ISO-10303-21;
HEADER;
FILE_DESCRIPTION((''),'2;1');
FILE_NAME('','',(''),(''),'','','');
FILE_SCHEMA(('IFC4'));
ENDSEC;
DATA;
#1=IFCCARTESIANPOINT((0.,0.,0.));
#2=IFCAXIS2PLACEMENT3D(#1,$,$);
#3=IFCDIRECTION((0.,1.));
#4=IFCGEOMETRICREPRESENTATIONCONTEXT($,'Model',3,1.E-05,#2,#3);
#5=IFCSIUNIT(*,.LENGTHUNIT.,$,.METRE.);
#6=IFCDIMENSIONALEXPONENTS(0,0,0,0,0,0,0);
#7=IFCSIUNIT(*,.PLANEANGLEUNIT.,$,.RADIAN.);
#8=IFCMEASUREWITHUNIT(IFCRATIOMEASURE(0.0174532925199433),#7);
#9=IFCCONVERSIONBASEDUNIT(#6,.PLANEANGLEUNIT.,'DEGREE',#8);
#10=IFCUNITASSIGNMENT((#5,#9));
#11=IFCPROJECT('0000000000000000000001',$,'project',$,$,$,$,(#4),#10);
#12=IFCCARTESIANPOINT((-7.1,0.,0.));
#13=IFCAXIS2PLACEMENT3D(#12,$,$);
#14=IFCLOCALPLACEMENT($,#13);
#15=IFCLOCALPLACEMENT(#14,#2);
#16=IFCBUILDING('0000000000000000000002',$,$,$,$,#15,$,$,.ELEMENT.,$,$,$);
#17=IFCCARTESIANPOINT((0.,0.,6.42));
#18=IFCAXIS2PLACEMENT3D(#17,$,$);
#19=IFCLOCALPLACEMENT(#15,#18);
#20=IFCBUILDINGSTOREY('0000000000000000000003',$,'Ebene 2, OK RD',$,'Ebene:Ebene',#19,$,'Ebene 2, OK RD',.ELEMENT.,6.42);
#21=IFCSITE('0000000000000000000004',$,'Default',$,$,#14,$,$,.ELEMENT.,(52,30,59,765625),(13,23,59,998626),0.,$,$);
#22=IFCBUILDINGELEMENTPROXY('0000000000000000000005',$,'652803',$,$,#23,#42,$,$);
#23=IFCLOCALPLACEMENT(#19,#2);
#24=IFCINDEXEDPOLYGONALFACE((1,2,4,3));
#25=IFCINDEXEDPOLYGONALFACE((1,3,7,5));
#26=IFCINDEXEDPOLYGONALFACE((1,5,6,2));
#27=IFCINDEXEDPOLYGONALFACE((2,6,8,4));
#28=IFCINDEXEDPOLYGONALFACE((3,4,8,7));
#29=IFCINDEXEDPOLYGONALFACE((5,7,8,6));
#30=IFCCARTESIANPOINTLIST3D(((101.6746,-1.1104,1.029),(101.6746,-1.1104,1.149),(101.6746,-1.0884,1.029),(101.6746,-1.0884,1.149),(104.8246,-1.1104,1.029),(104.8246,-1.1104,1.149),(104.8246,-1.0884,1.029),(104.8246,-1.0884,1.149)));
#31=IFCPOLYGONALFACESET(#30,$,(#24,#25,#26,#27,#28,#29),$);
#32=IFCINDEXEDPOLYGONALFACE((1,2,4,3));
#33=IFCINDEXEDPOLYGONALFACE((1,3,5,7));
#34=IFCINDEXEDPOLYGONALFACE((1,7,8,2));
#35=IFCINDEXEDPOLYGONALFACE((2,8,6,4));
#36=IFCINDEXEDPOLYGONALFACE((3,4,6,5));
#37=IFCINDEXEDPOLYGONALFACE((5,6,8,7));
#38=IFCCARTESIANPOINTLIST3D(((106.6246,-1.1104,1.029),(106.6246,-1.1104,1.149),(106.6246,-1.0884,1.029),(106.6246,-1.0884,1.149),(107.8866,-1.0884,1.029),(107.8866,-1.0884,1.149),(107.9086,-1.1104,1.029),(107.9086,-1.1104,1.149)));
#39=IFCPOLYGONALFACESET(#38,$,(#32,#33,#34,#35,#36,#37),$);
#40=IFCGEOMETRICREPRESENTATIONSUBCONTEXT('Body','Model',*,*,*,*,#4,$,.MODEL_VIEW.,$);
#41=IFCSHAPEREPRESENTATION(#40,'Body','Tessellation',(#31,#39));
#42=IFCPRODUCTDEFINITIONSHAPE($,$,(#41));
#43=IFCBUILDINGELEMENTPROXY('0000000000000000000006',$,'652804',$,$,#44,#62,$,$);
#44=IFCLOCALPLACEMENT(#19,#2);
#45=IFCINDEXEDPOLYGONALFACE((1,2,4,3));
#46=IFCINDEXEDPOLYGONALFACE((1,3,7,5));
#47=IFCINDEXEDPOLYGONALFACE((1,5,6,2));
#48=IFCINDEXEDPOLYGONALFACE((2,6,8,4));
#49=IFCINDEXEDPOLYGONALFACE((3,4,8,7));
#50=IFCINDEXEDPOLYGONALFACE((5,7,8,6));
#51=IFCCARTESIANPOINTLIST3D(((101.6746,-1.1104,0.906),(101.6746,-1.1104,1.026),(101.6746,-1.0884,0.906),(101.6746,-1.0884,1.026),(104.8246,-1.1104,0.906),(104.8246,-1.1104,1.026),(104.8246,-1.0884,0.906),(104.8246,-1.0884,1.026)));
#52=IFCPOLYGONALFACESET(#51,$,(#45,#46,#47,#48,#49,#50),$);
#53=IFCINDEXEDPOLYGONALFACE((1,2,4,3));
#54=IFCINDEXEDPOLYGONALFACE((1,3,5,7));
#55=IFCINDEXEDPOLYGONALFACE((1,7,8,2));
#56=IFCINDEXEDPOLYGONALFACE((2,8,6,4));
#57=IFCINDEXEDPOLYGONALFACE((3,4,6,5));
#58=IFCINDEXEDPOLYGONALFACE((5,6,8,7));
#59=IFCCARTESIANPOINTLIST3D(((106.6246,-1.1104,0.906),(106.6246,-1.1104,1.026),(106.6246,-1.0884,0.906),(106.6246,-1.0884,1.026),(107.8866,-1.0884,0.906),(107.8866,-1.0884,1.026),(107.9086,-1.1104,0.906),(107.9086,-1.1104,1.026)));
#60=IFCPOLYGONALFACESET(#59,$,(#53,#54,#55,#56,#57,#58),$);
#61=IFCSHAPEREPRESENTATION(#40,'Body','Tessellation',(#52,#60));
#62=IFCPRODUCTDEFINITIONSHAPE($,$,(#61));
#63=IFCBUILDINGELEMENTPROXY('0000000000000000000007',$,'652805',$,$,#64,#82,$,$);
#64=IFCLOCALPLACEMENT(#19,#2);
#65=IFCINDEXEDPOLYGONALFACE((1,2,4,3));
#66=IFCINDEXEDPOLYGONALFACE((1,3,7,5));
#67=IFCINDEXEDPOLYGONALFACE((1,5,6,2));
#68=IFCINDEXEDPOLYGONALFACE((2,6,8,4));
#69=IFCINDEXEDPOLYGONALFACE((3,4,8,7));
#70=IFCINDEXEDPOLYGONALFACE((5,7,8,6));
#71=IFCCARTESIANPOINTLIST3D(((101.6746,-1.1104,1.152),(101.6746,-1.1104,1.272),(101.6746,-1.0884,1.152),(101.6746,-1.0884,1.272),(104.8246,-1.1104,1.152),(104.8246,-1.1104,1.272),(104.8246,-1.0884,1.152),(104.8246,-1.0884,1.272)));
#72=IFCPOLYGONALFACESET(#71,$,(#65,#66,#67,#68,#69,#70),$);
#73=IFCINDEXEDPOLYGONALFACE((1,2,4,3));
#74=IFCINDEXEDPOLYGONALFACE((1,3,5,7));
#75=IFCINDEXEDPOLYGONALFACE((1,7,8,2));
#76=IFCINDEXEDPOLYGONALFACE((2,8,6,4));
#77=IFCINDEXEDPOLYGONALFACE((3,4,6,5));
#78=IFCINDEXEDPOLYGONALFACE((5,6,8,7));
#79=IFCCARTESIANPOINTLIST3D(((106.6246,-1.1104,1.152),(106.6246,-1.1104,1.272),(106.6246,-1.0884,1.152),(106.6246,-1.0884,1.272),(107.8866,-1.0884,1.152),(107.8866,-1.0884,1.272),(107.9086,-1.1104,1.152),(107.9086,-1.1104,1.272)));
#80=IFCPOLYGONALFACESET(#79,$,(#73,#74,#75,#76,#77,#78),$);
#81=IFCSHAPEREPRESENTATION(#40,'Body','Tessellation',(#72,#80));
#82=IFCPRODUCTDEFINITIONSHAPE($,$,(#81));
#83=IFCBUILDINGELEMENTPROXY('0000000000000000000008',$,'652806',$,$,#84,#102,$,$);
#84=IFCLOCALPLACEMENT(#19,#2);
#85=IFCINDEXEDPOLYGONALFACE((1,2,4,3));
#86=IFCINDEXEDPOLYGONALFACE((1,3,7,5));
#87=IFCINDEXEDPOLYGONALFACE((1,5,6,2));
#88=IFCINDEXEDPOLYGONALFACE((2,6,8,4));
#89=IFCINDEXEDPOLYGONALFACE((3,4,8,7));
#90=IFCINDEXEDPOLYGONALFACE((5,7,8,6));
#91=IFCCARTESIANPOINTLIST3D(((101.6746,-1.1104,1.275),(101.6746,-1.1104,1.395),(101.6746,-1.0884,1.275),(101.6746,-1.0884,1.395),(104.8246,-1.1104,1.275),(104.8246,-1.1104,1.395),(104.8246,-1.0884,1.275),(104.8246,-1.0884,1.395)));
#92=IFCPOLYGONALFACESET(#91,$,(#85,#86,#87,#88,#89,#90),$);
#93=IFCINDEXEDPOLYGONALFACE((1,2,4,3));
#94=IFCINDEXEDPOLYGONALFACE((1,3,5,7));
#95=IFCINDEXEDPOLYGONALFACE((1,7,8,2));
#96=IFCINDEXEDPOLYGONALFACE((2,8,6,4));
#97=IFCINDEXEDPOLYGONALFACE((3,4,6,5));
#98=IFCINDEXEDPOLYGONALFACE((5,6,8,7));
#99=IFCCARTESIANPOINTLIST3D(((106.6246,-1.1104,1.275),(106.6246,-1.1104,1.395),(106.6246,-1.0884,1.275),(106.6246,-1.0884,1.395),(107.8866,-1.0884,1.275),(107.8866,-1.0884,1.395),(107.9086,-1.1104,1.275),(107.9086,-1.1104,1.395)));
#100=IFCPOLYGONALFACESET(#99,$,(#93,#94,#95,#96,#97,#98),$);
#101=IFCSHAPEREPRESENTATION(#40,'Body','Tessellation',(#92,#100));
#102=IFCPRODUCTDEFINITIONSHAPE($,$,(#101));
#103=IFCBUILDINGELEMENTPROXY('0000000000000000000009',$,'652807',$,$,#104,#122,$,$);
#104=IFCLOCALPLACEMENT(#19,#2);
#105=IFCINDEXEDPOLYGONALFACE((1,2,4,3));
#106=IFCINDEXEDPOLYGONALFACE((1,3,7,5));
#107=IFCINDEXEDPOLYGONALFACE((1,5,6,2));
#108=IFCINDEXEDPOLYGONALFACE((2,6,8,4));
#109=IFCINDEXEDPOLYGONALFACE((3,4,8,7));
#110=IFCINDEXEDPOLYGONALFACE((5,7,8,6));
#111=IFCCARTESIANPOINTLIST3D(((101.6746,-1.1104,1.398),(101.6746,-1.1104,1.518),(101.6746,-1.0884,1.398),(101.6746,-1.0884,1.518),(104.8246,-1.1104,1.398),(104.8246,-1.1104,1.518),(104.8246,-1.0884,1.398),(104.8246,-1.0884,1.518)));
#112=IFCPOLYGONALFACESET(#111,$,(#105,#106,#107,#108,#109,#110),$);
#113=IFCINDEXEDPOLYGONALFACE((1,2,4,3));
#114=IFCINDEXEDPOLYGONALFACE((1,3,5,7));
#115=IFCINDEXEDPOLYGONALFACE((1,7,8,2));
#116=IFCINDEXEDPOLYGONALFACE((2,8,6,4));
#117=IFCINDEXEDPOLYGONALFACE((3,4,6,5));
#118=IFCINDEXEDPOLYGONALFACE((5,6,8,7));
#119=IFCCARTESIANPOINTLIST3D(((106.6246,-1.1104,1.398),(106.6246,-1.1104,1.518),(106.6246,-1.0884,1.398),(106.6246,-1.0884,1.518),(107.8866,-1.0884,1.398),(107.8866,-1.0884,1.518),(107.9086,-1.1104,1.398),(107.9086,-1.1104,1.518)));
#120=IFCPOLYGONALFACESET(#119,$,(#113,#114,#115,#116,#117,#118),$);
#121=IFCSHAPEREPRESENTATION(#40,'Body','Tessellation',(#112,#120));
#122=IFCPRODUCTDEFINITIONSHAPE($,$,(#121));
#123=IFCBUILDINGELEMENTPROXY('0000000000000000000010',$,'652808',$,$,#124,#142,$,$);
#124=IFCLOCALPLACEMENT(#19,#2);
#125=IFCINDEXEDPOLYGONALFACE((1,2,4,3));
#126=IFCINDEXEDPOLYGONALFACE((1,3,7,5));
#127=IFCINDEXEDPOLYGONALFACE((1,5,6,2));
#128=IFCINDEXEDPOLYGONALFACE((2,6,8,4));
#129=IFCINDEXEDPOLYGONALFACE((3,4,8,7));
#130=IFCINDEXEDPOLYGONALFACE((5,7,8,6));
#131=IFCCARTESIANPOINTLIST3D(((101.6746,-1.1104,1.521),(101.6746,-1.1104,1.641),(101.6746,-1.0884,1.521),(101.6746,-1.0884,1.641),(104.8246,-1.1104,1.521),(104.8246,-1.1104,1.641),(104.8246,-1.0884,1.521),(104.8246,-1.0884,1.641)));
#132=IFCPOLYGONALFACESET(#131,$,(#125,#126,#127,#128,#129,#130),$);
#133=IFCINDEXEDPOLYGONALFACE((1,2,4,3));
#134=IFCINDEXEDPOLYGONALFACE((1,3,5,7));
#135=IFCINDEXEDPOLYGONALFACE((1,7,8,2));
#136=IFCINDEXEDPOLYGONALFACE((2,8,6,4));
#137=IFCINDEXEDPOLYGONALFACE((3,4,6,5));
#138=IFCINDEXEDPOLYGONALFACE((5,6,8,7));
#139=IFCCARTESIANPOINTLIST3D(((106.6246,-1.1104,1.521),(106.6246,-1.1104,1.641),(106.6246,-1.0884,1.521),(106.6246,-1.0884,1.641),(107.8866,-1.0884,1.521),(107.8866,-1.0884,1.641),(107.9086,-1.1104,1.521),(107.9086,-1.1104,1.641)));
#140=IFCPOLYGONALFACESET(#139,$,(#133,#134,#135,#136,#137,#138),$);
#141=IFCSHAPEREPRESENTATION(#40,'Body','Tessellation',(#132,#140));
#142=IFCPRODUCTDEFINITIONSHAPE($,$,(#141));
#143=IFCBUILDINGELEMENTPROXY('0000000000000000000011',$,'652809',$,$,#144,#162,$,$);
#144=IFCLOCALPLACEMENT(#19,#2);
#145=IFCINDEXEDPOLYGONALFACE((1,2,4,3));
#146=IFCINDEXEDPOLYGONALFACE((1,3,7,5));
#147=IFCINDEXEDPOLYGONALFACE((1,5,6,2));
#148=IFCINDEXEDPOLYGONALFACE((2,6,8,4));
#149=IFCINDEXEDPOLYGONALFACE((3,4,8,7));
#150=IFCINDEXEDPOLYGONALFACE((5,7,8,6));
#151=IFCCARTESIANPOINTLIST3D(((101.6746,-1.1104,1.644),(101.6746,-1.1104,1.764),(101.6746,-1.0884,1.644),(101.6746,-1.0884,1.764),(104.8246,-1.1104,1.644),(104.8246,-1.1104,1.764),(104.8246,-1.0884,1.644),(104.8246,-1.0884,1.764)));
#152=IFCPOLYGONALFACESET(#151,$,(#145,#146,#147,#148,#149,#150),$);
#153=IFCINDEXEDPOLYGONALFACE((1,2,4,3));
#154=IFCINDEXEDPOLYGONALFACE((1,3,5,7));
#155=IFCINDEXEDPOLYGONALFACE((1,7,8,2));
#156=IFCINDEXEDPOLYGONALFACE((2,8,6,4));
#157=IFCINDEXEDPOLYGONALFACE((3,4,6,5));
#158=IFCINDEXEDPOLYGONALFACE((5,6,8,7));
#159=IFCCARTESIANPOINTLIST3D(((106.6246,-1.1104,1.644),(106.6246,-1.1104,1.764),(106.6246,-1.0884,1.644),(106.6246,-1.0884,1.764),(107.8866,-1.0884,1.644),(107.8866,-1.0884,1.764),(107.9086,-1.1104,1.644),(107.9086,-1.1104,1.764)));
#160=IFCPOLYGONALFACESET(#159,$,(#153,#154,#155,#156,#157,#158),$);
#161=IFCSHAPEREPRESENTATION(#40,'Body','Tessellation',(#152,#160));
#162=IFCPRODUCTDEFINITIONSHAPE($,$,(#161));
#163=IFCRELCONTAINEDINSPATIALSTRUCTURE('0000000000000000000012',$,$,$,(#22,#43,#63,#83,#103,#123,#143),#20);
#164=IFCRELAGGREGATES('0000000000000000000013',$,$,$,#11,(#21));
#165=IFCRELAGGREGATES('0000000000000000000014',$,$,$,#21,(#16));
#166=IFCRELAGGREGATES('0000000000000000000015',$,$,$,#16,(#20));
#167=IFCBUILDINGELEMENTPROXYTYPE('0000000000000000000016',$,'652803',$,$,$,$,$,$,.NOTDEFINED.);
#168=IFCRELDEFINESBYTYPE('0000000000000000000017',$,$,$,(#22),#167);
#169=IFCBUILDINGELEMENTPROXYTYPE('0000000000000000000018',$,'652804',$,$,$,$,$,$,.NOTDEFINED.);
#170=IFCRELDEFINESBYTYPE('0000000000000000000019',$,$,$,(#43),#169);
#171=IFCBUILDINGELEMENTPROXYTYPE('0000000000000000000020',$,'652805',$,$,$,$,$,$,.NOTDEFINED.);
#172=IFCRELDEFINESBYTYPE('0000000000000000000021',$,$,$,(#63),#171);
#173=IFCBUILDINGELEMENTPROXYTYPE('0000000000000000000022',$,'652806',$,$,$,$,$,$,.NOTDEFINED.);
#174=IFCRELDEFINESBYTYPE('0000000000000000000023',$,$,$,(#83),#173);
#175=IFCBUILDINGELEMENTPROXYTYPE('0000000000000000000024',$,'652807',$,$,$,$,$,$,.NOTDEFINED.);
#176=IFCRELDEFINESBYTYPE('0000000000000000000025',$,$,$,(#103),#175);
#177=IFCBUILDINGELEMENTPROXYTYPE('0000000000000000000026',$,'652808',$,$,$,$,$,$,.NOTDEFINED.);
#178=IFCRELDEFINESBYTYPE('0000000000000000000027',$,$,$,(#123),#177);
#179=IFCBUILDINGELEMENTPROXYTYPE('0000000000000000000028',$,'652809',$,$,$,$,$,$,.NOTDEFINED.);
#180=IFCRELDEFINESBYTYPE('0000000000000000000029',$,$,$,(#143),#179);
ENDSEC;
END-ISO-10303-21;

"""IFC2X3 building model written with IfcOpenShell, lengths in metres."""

from ifc_helpers import new_model, entity, si_unit, converted_unit, direction, frame, origin, origin_2d_with_axis, place, context, subcontext, project, spatial, polyline, rectangle, outline, extrude, type_object, element, save


model = new_model("IFC2X3")

# Units and contexts
model_context = context("Model", 3, precision=1e-05, world=origin(), true_north=direction((0.0, 1.0)))
body_context = subcontext(model_context, "Body", "Model", "MODEL_VIEW")
ifc_project = project(units=[si_unit("LENGTHUNIT", "METRE"), converted_unit("PLANEANGLEUNIT", "DEGREE", entity("IfcRatioMeasure", 0.0174532925199433), si_unit("PLANEANGLEUNIT", "RADIAN"), dimensions=[0, 0, 0, 0, 0, 0, 0])], contexts=[model_context])

# Site, building, storey
site_placement = place(None, frame((-7.1, 0.0, 0.0)))
site = spatial("IfcSite", under=ifc_project, at=site_placement, Name="Default", CompositionType="ELEMENT", RefLatitude=(52, 30, 59, 765625), RefLongitude=(13, 23, 59, 998626), RefElevation=0.0)
building_placement = place(site_placement, origin())
building = spatial("IfcBuilding", under=site, at=building_placement, CompositionType="ELEMENT")
storey_placement = place(building_placement, frame((0.0, 0.0, 6.42)))
storey = spatial("IfcBuildingStorey", under=building, at=storey_placement, Name="Ebene 2, OK RD", ObjectType="Ebene:Ebene", LongName="Ebene 2, OK RD", CompositionType="ELEMENT", Elevation=6.42)

# Building element proxies
building_element_proxy_type_1 = type_object("IfcBuildingElementProxyType", Name="652803", PredefinedType="NOTDEFINED")
proxy_1_placement = place(storey_placement, origin())
element("IfcBuildingElementProxy", 1, at=proxy_1_placement, inside=storey, type_object=building_element_proxy_type_1, Name="652803", context=body_context, shape_type="SweptSolid", body=[
    extrude(rectangle(XDim=3.15, YDim=0.022, at=origin_2d_with_axis()), frame((103.2496, -1.0994, 1.029), z_axis=(0.0, 0.0, 1.0), x_axis=(-1.0, 0.0, 0.0)), (0.0, 0.0, 1.0), 0.12),
    extrude(outline(polyline([(-0.6255, -0.011), (0.6365, -0.011), (0.6365, 0.011), (-0.6475, 0.011), (-0.6255, -0.011)])), frame((107.2611, -1.0994, 1.029), z_axis=(0.0, 0.0, 1.0), x_axis=(-1.0, 0.0, 0.0)), (0.0, 0.0, 1.0), 0.12),
])
building_element_proxy_type_2 = type_object("IfcBuildingElementProxyType", Name="652804", PredefinedType="NOTDEFINED")
proxy_2_placement = place(storey_placement, origin())
element("IfcBuildingElementProxy", 2, at=proxy_2_placement, inside=storey, type_object=building_element_proxy_type_2, Name="652804", context=body_context, shape_type="SweptSolid", body=[
    extrude(rectangle(XDim=3.15, YDim=0.022, at=origin_2d_with_axis()), frame((103.2496, -1.0994, 0.906), z_axis=(0.0, 0.0, 1.0), x_axis=(-1.0, 0.0, 0.0)), (0.0, 0.0, 1.0), 0.12),
    extrude(outline(polyline([(-0.6255, -0.011), (0.6365, -0.011), (0.6365, 0.011), (-0.6475, 0.011), (-0.6255, -0.011)])), frame((107.2611, -1.0994, 0.906), z_axis=(0.0, 0.0, 1.0), x_axis=(-1.0, 0.0, 0.0)), (0.0, 0.0, 1.0), 0.12),
])
building_element_proxy_type_3 = type_object("IfcBuildingElementProxyType", Name="652805", PredefinedType="NOTDEFINED")
proxy_3_placement = place(storey_placement, origin())
element("IfcBuildingElementProxy", 3, at=proxy_3_placement, inside=storey, type_object=building_element_proxy_type_3, Name="652805", context=body_context, shape_type="SweptSolid", body=[
    extrude(rectangle(XDim=3.15, YDim=0.022, at=origin_2d_with_axis()), frame((103.2496, -1.0994, 1.152), z_axis=(0.0, 0.0, 1.0), x_axis=(-1.0, 0.0, 0.0)), (0.0, 0.0, 1.0), 0.12),
    extrude(outline(polyline([(-0.6255, -0.011), (0.6365, -0.011), (0.6365, 0.011), (-0.6475, 0.011), (-0.6255, -0.011)])), frame((107.2611, -1.0994, 1.152), z_axis=(0.0, 0.0, 1.0), x_axis=(-1.0, 0.0, 0.0)), (0.0, 0.0, 1.0), 0.12),
])
building_element_proxy_type_4 = type_object("IfcBuildingElementProxyType", Name="652806", PredefinedType="NOTDEFINED")
proxy_4_placement = place(storey_placement, origin())
element("IfcBuildingElementProxy", 4, at=proxy_4_placement, inside=storey, type_object=building_element_proxy_type_4, Name="652806", context=body_context, shape_type="SweptSolid", body=[
    extrude(rectangle(XDim=3.15, YDim=0.022, at=origin_2d_with_axis()), frame((103.2496, -1.0994, 1.275), z_axis=(0.0, 0.0, 1.0), x_axis=(-1.0, 0.0, 0.0)), (0.0, 0.0, 1.0), 0.12),
    extrude(outline(polyline([(-0.6255, -0.011), (0.6365, -0.011), (0.6365, 0.011), (-0.6475, 0.011), (-0.6255, -0.011)])), frame((107.2611, -1.0994, 1.275), z_axis=(0.0, 0.0, 1.0), x_axis=(-1.0, 0.0, 0.0)), (0.0, 0.0, 1.0), 0.12),
])
building_element_proxy_type_5 = type_object("IfcBuildingElementProxyType", Name="652807", PredefinedType="NOTDEFINED")
proxy_5_placement = place(storey_placement, origin())
element("IfcBuildingElementProxy", 5, at=proxy_5_placement, inside=storey, type_object=building_element_proxy_type_5, Name="652807", context=body_context, shape_type="SweptSolid", body=[
    extrude(rectangle(XDim=3.15, YDim=0.022, at=origin_2d_with_axis()), frame((103.2496, -1.0994, 1.398), z_axis=(0.0, 0.0, 1.0), x_axis=(-1.0, 0.0, 0.0)), (0.0, 0.0, 1.0), 0.12),
    extrude(outline(polyline([(-0.6255, -0.011), (0.6365, -0.011), (0.6365, 0.011), (-0.6475, 0.011), (-0.6255, -0.011)])), frame((107.2611, -1.0994, 1.398), z_axis=(0.0, 0.0, 1.0), x_axis=(-1.0, 0.0, 0.0)), (0.0, 0.0, 1.0), 0.12),
])
building_element_proxy_type_6 = type_object("IfcBuildingElementProxyType", Name="652808", PredefinedType="NOTDEFINED")
proxy_6_placement = place(storey_placement, origin())
element("IfcBuildingElementProxy", 6, at=proxy_6_placement, inside=storey, type_object=building_element_proxy_type_6, Name="652808", context=body_context, shape_type="SweptSolid", body=[
    extrude(rectangle(XDim=3.15, YDim=0.022, at=origin_2d_with_axis()), frame((103.2496, -1.0994, 1.521), z_axis=(0.0, 0.0, 1.0), x_axis=(-1.0, 0.0, 0.0)), (0.0, 0.0, 1.0), 0.12),
    extrude(outline(polyline([(-0.6255, -0.011), (0.6365, -0.011), (0.6365, 0.011), (-0.6475, 0.011), (-0.6255, -0.011)])), frame((107.2611, -1.0994, 1.521), z_axis=(0.0, 0.0, 1.0), x_axis=(-1.0, 0.0, 0.0)), (0.0, 0.0, 1.0), 0.12),
])
building_element_proxy_type_7 = type_object("IfcBuildingElementProxyType", Name="652809", PredefinedType="NOTDEFINED")
proxy_7_placement = place(storey_placement, origin())
element("IfcBuildingElementProxy", 7, at=proxy_7_placement, inside=storey, type_object=building_element_proxy_type_7, Name="652809", context=body_context, shape_type="SweptSolid", body=[
    extrude(rectangle(XDim=3.15, YDim=0.022, at=origin_2d_with_axis()), frame((103.2496, -1.0994, 1.644), z_axis=(0.0, 0.0, 1.0), x_axis=(-1.0, 0.0, 0.0)), (0.0, 0.0, 1.0), 0.12),
    extrude(outline(polyline([(-0.6255, -0.011), (0.6365, -0.011), (0.6365, 0.011), (-0.6475, 0.011), (-0.6255, -0.011)])), frame((107.2611, -1.0994, 1.644), z_axis=(0.0, 0.0, 1.0), x_axis=(-1.0, 0.0, 0.0)), (0.0, 0.0, 1.0), 0.12),
])

save(model, "model.ifc")
